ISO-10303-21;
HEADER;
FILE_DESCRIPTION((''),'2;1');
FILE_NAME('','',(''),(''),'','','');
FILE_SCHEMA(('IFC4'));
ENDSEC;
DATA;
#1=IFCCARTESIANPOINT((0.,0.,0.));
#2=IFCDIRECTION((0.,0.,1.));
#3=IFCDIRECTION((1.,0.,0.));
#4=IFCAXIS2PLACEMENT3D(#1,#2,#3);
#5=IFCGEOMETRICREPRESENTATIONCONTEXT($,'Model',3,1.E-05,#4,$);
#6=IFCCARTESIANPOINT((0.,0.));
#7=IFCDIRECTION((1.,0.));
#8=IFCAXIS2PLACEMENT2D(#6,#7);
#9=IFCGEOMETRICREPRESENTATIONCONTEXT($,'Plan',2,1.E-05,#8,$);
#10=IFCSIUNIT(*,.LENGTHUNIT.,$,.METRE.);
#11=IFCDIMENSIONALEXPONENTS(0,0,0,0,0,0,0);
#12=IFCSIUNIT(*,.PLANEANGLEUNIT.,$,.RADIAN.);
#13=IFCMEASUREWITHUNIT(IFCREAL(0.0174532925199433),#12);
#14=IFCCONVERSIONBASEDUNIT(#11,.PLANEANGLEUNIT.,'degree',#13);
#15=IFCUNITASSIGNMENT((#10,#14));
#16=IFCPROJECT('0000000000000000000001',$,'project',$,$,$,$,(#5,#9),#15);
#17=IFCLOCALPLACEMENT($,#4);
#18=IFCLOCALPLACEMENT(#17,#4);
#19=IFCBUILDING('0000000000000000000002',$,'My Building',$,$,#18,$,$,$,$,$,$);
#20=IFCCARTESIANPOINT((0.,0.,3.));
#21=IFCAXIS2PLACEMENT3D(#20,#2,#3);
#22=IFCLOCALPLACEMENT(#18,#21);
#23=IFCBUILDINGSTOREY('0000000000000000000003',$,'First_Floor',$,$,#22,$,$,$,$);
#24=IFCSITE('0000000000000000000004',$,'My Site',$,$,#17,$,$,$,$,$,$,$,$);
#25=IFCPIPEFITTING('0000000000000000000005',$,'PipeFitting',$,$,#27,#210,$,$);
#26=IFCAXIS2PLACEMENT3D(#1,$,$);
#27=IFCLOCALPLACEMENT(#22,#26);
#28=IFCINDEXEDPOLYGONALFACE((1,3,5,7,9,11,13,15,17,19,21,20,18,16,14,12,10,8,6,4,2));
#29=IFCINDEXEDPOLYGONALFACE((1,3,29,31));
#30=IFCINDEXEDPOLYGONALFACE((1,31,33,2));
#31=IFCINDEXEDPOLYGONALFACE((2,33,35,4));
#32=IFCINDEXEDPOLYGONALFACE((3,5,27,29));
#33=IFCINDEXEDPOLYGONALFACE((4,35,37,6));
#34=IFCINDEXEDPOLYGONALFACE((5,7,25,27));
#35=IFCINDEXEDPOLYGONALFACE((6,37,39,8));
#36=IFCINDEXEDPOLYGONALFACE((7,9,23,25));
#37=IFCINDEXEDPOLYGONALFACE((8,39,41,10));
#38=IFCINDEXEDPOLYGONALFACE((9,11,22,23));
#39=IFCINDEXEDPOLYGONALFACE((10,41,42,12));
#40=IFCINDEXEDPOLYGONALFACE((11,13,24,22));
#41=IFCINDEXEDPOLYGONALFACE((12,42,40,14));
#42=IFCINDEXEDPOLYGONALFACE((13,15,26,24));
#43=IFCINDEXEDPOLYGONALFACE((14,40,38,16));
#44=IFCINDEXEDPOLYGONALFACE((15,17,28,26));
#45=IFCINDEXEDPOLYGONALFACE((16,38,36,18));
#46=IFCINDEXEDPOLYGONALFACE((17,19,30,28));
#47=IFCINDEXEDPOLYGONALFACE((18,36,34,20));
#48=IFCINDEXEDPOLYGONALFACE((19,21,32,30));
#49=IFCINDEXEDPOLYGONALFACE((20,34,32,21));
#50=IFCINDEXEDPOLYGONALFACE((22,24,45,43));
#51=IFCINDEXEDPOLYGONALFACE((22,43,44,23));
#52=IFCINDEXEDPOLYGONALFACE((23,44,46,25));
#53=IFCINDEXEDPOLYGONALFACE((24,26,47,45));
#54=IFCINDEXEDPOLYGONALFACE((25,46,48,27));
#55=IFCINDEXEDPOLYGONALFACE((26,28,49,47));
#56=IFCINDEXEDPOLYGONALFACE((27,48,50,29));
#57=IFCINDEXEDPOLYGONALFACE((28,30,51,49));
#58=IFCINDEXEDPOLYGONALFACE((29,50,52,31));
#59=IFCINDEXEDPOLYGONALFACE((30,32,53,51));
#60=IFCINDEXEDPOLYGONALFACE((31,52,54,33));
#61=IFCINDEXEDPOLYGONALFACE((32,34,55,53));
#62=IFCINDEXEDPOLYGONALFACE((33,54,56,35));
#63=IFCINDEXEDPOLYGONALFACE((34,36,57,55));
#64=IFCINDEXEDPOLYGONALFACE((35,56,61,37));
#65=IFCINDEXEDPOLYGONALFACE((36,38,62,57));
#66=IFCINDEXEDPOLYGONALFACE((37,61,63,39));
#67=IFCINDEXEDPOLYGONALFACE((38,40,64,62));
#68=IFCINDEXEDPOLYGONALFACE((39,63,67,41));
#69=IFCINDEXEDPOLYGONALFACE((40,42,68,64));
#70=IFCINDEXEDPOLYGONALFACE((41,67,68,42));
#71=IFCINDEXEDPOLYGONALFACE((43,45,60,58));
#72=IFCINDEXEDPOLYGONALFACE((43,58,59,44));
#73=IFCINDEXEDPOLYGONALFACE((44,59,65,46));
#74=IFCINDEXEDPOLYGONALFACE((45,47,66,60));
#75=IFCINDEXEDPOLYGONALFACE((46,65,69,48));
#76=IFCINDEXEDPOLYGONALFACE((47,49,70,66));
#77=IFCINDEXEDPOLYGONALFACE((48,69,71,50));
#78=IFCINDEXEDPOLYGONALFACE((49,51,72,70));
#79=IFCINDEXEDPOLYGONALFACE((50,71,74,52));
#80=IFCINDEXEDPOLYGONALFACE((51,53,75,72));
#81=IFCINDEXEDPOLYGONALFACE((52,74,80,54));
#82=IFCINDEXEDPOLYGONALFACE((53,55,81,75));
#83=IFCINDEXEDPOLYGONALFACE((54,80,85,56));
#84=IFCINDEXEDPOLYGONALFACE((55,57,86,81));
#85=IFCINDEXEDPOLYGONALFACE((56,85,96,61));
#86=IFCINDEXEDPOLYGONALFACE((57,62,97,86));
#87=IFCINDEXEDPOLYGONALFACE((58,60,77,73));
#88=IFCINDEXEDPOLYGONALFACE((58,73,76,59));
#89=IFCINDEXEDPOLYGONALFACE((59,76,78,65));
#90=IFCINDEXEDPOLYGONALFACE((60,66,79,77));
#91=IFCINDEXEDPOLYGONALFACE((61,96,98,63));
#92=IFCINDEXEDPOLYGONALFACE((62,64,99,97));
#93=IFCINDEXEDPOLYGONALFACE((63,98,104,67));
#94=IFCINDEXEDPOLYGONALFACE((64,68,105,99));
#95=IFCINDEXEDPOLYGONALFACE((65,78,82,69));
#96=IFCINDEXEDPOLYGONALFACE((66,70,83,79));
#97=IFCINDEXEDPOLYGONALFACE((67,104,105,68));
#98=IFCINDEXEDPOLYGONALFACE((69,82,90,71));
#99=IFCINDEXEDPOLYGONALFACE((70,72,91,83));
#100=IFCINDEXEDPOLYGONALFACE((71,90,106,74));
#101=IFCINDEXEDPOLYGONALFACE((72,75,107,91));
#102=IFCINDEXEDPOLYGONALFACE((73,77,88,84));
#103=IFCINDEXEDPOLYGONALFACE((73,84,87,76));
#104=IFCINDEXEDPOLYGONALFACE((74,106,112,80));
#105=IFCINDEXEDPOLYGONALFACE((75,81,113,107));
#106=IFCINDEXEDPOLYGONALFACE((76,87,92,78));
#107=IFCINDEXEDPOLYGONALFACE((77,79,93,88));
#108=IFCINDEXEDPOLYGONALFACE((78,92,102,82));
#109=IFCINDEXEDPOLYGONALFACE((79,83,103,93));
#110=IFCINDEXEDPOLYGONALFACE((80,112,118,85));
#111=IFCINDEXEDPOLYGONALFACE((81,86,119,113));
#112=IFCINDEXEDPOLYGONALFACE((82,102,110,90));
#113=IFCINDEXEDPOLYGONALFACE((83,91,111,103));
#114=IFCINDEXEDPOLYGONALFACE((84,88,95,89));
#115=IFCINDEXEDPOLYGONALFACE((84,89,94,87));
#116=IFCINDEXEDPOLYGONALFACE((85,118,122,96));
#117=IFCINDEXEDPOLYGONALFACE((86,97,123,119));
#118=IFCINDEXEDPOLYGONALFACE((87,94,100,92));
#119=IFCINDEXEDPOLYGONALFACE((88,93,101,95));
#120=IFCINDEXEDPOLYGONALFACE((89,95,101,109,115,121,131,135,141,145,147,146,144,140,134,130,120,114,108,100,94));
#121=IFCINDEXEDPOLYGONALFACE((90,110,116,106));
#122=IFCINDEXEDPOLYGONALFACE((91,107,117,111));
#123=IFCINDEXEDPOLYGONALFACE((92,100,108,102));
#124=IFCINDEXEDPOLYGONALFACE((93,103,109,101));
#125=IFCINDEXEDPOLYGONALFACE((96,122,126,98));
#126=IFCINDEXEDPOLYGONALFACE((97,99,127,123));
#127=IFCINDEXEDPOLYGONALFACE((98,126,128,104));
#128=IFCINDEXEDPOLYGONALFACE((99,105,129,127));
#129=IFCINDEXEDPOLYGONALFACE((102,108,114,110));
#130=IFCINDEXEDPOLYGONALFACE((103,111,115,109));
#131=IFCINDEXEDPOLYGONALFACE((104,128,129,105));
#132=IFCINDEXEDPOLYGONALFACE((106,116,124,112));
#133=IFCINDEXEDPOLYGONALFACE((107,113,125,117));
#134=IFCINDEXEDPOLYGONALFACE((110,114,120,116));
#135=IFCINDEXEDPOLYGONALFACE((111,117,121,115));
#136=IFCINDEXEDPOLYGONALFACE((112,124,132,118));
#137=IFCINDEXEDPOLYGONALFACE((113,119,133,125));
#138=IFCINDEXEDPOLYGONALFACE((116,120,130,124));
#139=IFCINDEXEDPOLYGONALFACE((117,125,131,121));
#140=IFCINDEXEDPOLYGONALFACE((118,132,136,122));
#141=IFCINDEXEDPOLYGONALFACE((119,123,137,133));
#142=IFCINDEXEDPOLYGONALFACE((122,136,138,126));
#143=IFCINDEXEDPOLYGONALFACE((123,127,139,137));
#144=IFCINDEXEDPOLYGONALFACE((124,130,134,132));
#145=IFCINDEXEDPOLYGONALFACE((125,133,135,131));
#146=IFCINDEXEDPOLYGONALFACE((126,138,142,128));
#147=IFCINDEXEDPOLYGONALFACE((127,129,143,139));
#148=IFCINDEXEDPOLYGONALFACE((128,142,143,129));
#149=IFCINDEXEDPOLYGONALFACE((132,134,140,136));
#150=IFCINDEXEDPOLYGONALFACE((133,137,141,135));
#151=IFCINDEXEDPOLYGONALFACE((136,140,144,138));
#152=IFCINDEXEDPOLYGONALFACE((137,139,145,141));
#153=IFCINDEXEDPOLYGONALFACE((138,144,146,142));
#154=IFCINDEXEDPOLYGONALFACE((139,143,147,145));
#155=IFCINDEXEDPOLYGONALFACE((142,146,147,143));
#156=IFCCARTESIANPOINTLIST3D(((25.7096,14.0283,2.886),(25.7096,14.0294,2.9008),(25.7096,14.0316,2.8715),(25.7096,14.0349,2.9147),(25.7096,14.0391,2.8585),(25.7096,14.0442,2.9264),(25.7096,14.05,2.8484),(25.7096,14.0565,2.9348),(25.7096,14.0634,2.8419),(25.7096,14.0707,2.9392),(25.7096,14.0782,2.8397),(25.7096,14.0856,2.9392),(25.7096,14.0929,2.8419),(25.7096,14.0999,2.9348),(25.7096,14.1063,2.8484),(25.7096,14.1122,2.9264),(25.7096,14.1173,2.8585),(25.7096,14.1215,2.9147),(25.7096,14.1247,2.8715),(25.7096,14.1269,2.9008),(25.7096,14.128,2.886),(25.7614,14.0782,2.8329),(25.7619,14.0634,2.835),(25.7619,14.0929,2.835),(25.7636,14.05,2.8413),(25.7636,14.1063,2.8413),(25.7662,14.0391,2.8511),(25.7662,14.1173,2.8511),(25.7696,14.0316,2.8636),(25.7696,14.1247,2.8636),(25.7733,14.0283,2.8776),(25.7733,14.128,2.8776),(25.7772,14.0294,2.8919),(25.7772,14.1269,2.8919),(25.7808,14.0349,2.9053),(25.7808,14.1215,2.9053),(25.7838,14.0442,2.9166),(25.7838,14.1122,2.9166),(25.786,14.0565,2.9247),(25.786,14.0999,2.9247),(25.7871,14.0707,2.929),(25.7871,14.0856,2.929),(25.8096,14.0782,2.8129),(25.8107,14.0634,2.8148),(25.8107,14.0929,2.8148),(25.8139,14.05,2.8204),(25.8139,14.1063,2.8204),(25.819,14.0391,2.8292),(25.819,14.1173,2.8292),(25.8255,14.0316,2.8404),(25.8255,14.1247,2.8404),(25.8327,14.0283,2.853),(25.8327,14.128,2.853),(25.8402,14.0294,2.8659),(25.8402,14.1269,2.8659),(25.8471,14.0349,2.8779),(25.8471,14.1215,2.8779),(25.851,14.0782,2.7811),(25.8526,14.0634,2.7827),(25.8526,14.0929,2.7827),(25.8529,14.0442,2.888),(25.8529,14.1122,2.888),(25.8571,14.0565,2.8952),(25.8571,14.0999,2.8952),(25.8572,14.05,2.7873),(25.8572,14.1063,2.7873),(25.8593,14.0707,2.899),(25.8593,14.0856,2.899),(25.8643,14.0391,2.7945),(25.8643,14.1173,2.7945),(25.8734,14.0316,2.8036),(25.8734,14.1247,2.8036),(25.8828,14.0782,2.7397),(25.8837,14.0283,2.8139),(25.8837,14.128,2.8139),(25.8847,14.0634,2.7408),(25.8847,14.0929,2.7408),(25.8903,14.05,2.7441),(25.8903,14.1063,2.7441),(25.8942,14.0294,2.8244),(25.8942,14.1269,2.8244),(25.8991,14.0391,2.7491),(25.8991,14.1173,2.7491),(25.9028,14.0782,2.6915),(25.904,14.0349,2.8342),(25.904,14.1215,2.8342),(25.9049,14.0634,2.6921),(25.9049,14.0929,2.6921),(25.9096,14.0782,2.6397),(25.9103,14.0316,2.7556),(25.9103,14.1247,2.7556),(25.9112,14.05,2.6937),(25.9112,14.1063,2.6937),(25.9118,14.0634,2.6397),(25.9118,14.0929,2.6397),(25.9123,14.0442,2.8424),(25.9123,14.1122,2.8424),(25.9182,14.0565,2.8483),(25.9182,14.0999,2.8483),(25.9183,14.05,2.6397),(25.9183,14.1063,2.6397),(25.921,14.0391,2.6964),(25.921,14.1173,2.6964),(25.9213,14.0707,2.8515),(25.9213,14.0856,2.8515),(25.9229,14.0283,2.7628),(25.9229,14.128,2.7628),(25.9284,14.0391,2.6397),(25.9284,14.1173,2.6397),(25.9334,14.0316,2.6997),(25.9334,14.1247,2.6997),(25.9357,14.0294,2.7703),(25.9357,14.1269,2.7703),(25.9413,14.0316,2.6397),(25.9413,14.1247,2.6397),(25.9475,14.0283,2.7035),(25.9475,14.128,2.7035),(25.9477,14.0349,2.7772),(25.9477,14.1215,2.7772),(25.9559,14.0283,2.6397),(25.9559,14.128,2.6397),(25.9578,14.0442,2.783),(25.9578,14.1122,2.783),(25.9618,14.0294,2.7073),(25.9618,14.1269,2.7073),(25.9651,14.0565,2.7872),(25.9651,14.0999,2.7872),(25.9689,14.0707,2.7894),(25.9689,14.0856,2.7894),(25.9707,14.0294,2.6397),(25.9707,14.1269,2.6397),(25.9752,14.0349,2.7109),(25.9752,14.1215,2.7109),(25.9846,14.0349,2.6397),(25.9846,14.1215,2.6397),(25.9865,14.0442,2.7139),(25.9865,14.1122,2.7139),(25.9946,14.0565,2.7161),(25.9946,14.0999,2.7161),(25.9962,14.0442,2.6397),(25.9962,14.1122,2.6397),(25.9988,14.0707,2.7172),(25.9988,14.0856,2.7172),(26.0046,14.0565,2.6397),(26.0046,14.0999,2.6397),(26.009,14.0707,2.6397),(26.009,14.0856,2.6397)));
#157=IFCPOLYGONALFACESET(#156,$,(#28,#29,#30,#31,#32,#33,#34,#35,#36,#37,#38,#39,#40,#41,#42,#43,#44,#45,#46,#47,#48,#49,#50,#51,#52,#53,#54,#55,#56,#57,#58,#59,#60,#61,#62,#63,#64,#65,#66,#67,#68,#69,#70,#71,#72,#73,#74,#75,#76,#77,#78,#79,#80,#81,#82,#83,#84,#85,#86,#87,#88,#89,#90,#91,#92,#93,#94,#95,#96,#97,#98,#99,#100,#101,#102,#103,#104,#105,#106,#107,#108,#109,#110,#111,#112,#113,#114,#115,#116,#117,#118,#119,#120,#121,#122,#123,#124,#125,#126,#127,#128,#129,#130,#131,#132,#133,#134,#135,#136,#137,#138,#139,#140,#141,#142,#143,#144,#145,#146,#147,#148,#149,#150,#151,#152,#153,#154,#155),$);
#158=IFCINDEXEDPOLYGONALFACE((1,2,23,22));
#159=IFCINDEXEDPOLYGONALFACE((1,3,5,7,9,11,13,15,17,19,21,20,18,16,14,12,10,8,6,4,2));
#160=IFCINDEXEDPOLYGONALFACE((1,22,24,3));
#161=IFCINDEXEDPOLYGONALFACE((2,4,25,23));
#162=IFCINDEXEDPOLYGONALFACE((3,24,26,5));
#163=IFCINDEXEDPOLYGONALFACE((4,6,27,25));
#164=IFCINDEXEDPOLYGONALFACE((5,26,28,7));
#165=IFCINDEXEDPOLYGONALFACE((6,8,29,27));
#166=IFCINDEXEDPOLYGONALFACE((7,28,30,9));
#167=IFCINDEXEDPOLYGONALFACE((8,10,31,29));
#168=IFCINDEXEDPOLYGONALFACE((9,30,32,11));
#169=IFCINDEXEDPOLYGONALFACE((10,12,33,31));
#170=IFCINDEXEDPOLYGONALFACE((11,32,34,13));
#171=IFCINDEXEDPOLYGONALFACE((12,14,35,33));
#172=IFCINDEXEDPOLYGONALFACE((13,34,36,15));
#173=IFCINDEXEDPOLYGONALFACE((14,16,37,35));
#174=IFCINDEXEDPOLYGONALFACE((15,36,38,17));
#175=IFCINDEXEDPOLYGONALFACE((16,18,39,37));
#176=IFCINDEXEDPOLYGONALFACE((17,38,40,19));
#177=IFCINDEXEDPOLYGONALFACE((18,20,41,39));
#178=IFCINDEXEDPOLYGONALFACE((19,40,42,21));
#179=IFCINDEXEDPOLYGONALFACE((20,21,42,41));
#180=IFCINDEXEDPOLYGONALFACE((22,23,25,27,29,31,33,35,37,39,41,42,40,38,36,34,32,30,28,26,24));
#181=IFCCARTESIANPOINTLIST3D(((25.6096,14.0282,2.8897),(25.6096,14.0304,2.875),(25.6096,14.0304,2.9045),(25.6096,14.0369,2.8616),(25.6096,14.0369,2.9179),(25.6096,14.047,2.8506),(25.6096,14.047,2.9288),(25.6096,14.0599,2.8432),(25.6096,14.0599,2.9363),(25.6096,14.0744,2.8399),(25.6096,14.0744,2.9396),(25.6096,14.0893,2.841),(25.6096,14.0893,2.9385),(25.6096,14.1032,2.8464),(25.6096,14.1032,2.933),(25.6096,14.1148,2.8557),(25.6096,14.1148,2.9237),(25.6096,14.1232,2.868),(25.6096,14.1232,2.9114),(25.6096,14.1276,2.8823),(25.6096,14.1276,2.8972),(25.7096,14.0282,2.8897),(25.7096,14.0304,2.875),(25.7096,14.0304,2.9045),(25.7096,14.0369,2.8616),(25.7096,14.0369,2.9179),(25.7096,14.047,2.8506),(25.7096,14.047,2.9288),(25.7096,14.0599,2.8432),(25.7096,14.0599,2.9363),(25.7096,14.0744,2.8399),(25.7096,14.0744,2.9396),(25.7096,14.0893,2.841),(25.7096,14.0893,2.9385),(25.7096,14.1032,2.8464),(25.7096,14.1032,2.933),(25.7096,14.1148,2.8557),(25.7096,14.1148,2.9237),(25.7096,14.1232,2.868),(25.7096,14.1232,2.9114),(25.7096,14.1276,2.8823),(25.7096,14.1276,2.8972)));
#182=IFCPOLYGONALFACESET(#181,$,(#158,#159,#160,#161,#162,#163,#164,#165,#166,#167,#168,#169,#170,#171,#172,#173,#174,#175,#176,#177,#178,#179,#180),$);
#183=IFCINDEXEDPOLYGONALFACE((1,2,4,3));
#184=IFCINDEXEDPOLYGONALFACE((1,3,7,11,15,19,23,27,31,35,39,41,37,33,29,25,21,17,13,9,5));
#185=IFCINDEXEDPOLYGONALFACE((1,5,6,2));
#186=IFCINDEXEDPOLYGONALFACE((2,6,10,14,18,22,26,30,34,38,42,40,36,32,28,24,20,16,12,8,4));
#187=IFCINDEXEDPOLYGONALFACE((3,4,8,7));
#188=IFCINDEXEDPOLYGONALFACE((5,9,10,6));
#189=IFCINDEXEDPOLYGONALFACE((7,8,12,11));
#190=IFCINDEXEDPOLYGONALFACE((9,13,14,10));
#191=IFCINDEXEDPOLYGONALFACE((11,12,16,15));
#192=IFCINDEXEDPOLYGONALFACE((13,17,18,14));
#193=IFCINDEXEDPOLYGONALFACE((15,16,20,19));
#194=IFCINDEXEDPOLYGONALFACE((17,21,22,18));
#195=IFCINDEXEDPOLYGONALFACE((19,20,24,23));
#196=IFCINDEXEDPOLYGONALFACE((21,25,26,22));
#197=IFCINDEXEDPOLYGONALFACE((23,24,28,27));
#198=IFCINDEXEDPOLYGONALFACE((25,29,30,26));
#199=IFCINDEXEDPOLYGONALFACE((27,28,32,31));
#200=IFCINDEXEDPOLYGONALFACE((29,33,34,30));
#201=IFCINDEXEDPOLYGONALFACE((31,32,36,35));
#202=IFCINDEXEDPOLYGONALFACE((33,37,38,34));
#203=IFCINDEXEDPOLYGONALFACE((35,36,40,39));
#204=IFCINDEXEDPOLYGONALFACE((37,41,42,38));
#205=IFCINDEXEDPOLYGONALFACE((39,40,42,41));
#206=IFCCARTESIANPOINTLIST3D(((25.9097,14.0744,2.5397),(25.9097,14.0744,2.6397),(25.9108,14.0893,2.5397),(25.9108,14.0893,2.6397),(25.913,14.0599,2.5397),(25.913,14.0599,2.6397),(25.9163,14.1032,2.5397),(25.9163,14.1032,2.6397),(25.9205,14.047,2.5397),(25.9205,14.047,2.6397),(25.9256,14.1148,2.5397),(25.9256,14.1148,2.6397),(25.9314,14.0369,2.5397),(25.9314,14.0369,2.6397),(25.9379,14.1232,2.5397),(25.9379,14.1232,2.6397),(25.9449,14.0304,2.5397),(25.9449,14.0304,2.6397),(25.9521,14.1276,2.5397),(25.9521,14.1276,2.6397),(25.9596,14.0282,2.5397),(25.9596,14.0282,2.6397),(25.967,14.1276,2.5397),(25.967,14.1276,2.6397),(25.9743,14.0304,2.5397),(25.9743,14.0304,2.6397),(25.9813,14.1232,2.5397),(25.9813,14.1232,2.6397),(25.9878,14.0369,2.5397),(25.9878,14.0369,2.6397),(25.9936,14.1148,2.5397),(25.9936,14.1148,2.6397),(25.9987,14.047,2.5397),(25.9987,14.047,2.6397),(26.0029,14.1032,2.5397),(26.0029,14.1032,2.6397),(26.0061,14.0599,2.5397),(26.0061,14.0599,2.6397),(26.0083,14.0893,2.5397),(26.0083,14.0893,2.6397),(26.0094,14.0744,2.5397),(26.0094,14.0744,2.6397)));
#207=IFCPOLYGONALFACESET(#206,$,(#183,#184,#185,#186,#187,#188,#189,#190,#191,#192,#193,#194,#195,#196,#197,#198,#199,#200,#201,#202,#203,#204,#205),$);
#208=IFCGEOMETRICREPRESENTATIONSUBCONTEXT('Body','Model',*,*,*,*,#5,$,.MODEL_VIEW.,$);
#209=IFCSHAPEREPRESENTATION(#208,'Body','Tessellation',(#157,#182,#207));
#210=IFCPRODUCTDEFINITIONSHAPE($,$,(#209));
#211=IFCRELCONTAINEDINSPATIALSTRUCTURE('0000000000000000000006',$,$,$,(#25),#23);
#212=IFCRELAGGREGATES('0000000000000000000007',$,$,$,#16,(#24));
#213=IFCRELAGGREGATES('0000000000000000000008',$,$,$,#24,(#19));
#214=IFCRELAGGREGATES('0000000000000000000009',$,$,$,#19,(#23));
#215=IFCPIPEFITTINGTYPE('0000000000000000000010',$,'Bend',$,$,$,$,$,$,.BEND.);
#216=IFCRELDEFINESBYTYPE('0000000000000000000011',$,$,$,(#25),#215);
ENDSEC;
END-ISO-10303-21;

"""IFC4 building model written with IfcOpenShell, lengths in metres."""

from ifc_helpers import new_model, entity, si_unit, converted_unit, frame, origin_with_axes, origin_2d_with_axis, place, context, subcontext, project, spatial, circle, extrude, source, transform, mapped, type_object, type_shapes, element, save


model = new_model("IFC4")

# Units and contexts
model_context = context("Model", 3, precision=1e-05, world=origin_with_axes())
plan_context = context("Plan", 2, precision=1e-05, world=origin_2d_with_axis())
body_context_1 = subcontext(model_context, "Body", "Model", "MODEL_VIEW")
ifc_project = project(units=[si_unit("LENGTHUNIT", "METRE"), converted_unit("PLANEANGLEUNIT", "degree", entity("IfcReal", 0.0174532925199433), si_unit("PLANEANGLEUNIT", "RADIAN"), dimensions=[0, 0, 0, 0, 0, 0, 0])], contexts=[model_context, plan_context])

# Site, building, storey
site_placement = place(None, origin_with_axes())
site = spatial("IfcSite", under=ifc_project, at=site_placement, Name="My Site")
building_placement = place(site_placement, origin_with_axes())
building = spatial("IfcBuilding", under=site, at=building_placement, Name="My Building")
storey_placement = place(building_placement, frame((0.0, 0.0, 3.0), z_axis=(0.0, 0.0, 1.0), x_axis=(1.0, 0.0, 0.0)))
storey = spatial("IfcBuildingStorey", under=building, at=storey_placement, Name="First_Floor")

# Pipe fitting
pipe_fitting_type = type_object("IfcPipeFittingType", Name="Bend", PredefinedType="BEND")
shared_shape_1 = source(origin_with_axes(), body_context_1, "Body", "SolidModel", [
    entity("IfcSweptDiskSolid", entity("IfcIndexedPolyCurve", entity("IfcCartesianPointList3D", [[0.0, 0.0, -0.1], [0.0, -0.0732, -0.2768], [0.0, -0.25, -0.35]]), [entity("IfcArcIndex", [1, 2, 3])]), 0.05),
    extrude(circle(Radius=0.05), origin_with_axes(), (0.0, 0.0, -1.0), 0.1),
    extrude(circle(Radius=0.05), frame((0.0, -0.25, -0.35), z_axis=(0.0, -1.0, 0.0), x_axis=(1.0, 0.0, 0.0)), (0.0, 0.0, 1.0), 0.1),
])
type_shapes(pipe_fitting_type, [shared_shape_1])
for number, where, z_axis, x_axis, name in (
    (1, (25.6096, 14.0782, 2.8897), (-1.0, 0.0, 0.0), (0.0, -1.0, 0.0), "PipeFitting"),
):
    element("IfcPipeFitting", number, at=place(storey_placement, frame(where, z_axis=z_axis, x_axis=x_axis)), inside=storey, type_object=pipe_fitting_type, Name=name, context=body_context_1, shape_type="MappedRepresentation", body=[
        mapped(shared_shape_1, transform((0.0, 0.0, 0.0), x_axis=(1.0, 0.0, 0.0), y_axis=(0.0, 1.0, 0.0), z_axis=(0.0, 0.0, 1.0), scale=1.0)),
    ])

save(model, "model.ifc")
